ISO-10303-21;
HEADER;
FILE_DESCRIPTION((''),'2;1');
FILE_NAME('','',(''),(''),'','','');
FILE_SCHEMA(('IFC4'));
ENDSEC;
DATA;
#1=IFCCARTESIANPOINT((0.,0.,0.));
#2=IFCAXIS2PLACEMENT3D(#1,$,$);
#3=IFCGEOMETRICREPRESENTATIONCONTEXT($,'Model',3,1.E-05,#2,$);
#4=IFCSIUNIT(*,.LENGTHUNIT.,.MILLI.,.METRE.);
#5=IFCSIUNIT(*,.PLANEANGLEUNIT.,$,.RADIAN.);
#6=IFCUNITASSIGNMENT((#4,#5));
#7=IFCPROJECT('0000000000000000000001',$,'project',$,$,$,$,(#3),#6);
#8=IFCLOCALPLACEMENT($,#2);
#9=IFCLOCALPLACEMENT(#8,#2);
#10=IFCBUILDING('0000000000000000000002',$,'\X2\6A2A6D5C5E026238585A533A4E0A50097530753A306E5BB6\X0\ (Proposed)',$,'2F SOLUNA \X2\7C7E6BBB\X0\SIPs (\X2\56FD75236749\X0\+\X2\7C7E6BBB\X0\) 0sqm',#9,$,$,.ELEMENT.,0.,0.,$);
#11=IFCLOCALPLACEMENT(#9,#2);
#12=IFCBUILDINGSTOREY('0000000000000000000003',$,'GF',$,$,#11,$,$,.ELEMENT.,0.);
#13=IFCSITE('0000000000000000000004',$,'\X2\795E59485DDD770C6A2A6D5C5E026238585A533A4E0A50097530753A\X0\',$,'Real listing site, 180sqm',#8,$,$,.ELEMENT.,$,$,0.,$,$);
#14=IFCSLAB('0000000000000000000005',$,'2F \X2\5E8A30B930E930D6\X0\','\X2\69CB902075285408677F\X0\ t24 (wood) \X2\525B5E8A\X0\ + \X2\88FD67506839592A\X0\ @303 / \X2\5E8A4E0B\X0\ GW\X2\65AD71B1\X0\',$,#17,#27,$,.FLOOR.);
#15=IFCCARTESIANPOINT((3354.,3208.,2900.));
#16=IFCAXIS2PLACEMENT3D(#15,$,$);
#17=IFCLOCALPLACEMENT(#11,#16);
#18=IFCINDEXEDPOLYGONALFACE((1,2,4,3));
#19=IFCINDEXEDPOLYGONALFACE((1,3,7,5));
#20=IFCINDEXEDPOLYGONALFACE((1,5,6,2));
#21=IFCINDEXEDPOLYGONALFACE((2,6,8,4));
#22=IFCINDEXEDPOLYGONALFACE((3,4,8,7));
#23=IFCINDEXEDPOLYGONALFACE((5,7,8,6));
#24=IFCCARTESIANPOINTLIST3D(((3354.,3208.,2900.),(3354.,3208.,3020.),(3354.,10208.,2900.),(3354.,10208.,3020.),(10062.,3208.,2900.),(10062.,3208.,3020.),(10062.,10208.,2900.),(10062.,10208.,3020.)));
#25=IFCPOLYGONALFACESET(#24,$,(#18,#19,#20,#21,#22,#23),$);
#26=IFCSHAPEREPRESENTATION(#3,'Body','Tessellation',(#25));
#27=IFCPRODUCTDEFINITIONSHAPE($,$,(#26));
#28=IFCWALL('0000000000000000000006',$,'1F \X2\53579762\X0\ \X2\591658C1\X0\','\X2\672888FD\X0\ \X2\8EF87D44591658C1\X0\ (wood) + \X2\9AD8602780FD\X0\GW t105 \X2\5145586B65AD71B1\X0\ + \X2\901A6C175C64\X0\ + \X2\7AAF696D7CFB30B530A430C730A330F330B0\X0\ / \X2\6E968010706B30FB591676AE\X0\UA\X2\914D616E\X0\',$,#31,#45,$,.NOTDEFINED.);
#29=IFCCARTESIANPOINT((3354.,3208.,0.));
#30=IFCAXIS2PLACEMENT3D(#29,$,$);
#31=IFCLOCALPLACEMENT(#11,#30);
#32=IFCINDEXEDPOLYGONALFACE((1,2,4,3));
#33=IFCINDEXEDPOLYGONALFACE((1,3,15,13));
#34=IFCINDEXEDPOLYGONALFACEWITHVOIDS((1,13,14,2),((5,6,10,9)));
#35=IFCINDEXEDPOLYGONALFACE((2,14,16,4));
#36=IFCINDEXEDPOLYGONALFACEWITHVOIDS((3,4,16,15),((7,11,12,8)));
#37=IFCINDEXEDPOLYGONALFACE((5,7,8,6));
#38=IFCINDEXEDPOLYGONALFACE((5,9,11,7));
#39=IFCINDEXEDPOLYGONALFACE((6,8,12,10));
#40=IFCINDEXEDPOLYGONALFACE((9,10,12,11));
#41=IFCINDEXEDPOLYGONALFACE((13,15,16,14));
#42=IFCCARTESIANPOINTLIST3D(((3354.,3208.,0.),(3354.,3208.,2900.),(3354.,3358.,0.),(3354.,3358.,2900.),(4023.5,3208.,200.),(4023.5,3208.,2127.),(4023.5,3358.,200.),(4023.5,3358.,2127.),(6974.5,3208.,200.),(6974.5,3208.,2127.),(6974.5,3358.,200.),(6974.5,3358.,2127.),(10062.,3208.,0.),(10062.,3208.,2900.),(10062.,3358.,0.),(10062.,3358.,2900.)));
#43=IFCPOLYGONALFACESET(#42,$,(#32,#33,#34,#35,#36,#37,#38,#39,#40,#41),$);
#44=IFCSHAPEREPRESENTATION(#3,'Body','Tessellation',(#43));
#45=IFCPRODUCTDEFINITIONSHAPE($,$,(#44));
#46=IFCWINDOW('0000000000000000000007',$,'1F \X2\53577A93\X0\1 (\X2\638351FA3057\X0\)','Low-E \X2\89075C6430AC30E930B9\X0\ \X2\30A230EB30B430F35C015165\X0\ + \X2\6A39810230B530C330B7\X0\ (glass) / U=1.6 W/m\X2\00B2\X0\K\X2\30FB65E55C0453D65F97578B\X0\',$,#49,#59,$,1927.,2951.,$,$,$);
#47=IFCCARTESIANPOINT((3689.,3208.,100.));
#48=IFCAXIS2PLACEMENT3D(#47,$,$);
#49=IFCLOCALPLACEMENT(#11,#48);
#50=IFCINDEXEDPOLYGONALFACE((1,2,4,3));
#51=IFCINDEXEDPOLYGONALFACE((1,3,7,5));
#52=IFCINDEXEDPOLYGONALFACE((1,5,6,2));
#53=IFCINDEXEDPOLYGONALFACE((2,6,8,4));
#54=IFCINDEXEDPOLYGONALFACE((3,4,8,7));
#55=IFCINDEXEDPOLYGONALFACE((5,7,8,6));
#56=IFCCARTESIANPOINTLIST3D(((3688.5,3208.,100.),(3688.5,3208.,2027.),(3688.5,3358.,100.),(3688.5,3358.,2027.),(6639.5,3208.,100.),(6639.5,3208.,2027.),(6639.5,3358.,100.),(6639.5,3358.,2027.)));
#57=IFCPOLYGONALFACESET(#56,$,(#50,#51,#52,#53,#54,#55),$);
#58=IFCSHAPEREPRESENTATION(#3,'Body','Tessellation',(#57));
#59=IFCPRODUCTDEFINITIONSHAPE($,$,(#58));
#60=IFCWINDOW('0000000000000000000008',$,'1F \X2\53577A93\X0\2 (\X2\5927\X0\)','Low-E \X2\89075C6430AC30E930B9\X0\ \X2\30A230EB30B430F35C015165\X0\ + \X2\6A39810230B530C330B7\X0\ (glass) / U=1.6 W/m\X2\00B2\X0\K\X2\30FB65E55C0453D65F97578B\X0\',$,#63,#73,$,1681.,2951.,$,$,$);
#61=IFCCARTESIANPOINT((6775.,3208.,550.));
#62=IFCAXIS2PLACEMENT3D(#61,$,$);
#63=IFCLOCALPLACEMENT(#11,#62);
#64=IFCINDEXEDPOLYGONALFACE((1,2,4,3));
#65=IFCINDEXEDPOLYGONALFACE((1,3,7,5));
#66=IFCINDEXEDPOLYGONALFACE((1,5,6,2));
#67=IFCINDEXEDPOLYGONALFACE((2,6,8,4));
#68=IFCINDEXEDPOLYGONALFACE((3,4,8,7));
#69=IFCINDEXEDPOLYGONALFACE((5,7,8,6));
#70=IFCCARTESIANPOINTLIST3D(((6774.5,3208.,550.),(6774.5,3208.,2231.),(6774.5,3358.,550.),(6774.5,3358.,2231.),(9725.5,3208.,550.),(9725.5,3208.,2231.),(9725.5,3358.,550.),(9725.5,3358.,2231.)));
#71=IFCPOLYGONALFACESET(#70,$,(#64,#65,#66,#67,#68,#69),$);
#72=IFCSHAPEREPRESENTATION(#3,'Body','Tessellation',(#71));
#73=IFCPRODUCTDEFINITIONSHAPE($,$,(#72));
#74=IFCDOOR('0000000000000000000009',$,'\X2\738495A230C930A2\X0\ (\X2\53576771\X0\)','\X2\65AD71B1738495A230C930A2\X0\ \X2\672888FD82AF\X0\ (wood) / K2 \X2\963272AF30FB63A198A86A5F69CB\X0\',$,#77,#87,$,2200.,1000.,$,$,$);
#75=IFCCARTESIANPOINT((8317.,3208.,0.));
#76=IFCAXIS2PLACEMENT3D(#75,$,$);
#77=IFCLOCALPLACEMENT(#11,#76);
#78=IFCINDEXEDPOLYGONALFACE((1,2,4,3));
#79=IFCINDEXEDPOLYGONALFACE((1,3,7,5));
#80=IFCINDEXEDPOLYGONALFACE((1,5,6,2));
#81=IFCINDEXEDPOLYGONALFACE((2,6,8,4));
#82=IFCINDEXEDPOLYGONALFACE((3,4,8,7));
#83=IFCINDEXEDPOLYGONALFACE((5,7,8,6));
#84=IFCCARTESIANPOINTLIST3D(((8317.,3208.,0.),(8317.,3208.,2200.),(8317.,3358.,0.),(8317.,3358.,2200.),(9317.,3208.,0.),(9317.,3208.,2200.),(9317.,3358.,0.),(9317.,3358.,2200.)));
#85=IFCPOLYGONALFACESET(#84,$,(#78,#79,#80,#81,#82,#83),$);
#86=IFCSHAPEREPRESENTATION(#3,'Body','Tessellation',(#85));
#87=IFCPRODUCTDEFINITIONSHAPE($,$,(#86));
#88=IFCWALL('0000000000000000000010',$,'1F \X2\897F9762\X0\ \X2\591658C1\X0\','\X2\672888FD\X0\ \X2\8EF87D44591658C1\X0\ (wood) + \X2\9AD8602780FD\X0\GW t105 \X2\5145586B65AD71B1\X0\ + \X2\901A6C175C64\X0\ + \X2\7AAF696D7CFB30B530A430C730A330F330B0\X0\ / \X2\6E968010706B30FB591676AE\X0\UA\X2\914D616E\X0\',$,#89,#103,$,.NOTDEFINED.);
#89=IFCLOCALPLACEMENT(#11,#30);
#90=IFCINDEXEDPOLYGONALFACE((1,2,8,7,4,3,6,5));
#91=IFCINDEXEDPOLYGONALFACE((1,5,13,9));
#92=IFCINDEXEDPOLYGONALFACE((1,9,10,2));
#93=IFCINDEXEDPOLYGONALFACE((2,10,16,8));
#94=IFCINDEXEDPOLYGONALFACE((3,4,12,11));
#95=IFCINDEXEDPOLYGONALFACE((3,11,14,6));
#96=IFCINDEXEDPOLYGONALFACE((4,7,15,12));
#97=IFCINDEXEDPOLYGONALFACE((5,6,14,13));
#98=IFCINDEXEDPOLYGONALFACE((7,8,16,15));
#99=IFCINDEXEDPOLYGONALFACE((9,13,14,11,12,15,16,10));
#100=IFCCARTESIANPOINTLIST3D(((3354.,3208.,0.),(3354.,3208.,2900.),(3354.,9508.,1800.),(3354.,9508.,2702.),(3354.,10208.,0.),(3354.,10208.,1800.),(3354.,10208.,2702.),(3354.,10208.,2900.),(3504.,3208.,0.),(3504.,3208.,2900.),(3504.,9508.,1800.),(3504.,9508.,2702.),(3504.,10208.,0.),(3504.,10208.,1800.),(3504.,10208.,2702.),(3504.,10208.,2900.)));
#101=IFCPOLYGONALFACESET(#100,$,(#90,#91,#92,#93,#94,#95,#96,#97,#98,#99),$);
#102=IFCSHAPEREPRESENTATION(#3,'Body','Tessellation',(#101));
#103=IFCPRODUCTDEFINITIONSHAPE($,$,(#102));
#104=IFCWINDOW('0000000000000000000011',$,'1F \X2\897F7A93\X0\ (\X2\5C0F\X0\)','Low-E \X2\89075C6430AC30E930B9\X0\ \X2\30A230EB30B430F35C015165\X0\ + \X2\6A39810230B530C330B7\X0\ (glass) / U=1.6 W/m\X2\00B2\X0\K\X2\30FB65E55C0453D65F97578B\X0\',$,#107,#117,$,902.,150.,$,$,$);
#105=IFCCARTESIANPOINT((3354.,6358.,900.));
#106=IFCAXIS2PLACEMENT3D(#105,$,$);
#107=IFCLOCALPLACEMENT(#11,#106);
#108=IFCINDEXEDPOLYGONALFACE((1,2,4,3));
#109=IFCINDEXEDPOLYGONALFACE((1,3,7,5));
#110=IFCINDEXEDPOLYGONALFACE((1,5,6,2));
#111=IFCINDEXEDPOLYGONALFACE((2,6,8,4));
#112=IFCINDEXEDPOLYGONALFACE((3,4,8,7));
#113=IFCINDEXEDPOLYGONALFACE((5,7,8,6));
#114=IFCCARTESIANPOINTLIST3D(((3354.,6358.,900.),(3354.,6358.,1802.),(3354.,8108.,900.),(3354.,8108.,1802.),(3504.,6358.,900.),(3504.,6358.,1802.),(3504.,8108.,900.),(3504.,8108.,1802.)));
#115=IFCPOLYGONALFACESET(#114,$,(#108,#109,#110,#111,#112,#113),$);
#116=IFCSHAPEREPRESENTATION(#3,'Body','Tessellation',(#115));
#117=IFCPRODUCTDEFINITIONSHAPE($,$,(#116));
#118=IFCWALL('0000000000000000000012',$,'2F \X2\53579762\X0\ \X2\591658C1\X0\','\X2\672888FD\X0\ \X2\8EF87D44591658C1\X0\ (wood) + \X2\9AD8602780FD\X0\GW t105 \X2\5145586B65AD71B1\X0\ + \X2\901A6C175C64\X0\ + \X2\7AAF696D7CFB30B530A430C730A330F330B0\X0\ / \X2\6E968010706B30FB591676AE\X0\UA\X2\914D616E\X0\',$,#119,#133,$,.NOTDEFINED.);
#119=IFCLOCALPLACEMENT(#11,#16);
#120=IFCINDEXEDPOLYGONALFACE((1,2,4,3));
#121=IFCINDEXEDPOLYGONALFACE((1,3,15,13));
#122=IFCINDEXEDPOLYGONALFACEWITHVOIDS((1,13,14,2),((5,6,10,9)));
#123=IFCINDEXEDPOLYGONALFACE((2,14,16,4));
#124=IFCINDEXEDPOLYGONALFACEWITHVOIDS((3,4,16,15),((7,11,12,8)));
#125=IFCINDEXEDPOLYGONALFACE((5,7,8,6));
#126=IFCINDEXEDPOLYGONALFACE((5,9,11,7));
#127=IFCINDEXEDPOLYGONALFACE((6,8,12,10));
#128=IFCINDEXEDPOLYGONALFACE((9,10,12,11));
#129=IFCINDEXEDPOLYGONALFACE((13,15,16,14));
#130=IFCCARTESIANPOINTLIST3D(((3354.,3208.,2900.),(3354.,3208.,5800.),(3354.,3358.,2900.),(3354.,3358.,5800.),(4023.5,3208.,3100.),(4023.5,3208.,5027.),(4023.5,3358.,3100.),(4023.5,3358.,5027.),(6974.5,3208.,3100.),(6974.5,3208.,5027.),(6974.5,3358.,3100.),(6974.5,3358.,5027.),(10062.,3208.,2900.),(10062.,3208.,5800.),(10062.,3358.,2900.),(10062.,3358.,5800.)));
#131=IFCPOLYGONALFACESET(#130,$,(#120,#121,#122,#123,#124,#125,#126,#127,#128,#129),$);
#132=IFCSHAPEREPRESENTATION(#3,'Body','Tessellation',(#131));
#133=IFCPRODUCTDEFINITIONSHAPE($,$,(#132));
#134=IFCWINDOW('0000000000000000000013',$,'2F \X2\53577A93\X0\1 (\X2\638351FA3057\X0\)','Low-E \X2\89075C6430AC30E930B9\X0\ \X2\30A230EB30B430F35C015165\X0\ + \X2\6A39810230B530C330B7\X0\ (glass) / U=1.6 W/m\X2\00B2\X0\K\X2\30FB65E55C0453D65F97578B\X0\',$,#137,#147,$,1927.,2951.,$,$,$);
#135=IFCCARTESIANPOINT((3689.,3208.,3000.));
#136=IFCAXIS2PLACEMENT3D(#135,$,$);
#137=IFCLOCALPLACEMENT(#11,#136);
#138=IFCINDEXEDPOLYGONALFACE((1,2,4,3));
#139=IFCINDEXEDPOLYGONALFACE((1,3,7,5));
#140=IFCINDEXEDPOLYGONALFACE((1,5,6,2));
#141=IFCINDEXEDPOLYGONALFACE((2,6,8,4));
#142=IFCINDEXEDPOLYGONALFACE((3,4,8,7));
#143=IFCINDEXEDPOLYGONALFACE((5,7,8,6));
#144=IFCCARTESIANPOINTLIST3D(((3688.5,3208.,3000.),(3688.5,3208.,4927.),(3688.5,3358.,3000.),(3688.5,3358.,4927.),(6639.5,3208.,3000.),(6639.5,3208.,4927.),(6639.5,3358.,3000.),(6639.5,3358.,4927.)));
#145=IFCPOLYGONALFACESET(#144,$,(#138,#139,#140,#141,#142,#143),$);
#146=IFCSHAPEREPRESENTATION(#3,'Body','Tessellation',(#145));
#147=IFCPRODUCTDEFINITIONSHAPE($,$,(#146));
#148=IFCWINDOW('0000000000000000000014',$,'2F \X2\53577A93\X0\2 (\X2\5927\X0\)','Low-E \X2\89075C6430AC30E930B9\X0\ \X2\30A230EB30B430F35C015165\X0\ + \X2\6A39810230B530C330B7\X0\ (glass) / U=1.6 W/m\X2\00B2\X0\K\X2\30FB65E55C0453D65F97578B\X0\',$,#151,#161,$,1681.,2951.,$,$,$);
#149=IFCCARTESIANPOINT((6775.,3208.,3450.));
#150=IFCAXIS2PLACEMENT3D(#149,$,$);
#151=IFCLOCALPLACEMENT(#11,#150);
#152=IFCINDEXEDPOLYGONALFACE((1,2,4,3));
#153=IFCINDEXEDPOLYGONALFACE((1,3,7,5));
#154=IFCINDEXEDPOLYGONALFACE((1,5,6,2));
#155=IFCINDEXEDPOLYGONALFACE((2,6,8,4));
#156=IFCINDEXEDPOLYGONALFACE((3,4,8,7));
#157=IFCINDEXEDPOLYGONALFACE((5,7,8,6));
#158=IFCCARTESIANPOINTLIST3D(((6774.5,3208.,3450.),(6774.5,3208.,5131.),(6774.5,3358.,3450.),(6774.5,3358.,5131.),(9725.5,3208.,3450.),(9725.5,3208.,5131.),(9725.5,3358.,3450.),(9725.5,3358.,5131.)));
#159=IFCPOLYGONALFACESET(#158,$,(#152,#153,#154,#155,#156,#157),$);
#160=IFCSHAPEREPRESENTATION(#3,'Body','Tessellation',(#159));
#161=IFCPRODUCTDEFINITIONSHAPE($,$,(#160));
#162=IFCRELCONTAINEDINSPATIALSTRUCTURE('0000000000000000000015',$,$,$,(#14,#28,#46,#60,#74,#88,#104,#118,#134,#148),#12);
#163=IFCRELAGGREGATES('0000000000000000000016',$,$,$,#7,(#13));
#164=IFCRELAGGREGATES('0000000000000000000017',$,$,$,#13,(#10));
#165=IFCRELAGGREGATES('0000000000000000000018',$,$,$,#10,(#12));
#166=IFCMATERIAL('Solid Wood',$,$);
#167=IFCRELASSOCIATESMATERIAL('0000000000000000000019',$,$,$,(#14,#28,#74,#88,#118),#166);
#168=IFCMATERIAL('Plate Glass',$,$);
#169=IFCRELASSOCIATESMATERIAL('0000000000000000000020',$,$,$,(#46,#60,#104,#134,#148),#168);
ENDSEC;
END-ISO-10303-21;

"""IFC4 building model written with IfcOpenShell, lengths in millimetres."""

from ifc_helpers import new_model, si_unit, frame, frame_2d, origin, place, context, project, spatial, rectangle, extrude, material, element, fill, save


model = new_model("IFC4")

# Units and contexts
model_context = context("Model", 3, precision=1e-05, world=origin())
ifc_project = project(units=[si_unit("LENGTHUNIT", "METRE", prefix="MILLI"), si_unit("PLANEANGLEUNIT", "RADIAN")], contexts=[model_context])

# Site, building, storey
site_placement = place(None, origin())
site = spatial("IfcSite", under=ifc_project, at=site_placement, Name="神奈川県横浜市戸塚区上倉田町", ObjectType="Real listing site, 180sqm", CompositionType="ELEMENT", RefElevation=0.0)
building_placement = place(site_placement, origin())
building = spatial("IfcBuilding", under=site, at=building_placement, Name="横浜市戸塚区上倉田町の家 (Proposed)", ObjectType="2F SOLUNA 籾殻SIPs (国産杉+籾殻) 0sqm", CompositionType="ELEMENT", ElevationOfRefHeight=0.0, ElevationOfTerrain=0.0)
storey_placement = place(building_placement, origin())
storey = spatial("IfcBuildingStorey", under=building, at=storey_placement, Name="GF", CompositionType="ELEMENT", Elevation=0.0)

# Slab
ifc_material_1 = material(Name="Solid Wood")
slab_1_placement = place(storey_placement, frame((3354.0, 3208.0, 2900.0)))
element("IfcSlab", 1, at=slab_1_placement, inside=storey, material=ifc_material_1, Name="2F 床スラブ", Description="構造用合板 t24 (wood) 剛床 + 製材根太 @303 / 床下 GW断熱", PredefinedType="FLOOR", context=model_context, shape_type="SweptSolid", body=[
    extrude(rectangle(XDim=6708.0, YDim=7000.0, at=frame_2d((3354.0, 3500.0))), frame((3354.0, 3208.0, 2900.0)), (0.0, 0.0, 1.0), 120.0),
])

# Wall, openings, windows, door
wall_1_placement = place(storey_placement, frame((3354.0, 3208.0, 0.0)))
wall_1 = element("IfcWall", 2, at=wall_1_placement, inside=storey, material=ifc_material_1, Name="1F 南面 外壁", Description="木製 軸組外壁 (wood) + 高性能GW t105 充填断熱 + 通気層 + 窯業系サイディング / 準耐火・外皮UA配慮", PredefinedType="NOTDEFINED", context=model_context, shape_type="SweptSolid", body=[
    extrude(rectangle(XDim=6708.0, YDim=150.0, at=frame_2d((3354.0, 75.0))), frame((3354.0, 3208.0, 0.0)), (0.0, 0.0, 1.0), 2900.0),
])
opening_1_placement = place(storey_placement, frame((3689.0, 3208.0, 100.0)))
opening_1 = element("IfcOpeningElement", 3, at=opening_1_placement, cuts=wall_1, PredefinedType="NOTDEFINED", context=model_context, shape_type="SweptSolid", body=[
    extrude(rectangle(XDim=2951.0, YDim=150.0, at=frame_2d((1475.0, 75.0))), frame((3689.0, 3208.0, 100.0)), (0.0, 0.0, 1.0), 1927.0),
])
opening_2_placement = place(storey_placement, frame((6775.0, 3208.0, 550.0)))
opening_2 = element("IfcOpeningElement", 4, at=opening_2_placement, cuts=wall_1, PredefinedType="NOTDEFINED", context=model_context, shape_type="SweptSolid", body=[
    extrude(rectangle(XDim=2951.0, YDim=150.0, at=frame_2d((1475.0, 75.0))), frame((6775.0, 3208.0, 550.0)), (0.0, 0.0, 1.0), 1681.0),
])
opening_3_placement = place(storey_placement, frame((8317.0, 3208.0, 0.0)))
opening_3 = element("IfcOpeningElement", 5, at=opening_3_placement, cuts=wall_1, PredefinedType="NOTDEFINED", context=model_context, shape_type="SweptSolid", body=[
    extrude(rectangle(XDim=1000.0, YDim=150.0, at=frame_2d((500.0, 75.0))), frame((8317.0, 3208.0, 0.0)), (0.0, 0.0, 1.0), 2200.0),
])
ifc_material_2 = material(Name="Plate Glass")
window_1_placement = place(storey_placement, frame((3689.0, 3208.0, 100.0)))
window_1 = element("IfcWindow", 6, at=window_1_placement, inside=storey, material=ifc_material_2, Name="1F 南窓1 (掃出し)", Description="Low-E 複層ガラス アルゴン封入 + 樹脂サッシ (glass) / U=1.6 W/m²K・日射取得型", OverallHeight=1927.0, OverallWidth=2951.0, context=model_context, shape_type="SweptSolid", body=[
    extrude(rectangle(XDim=2951.0, YDim=150.0, at=frame_2d((1475.0, 75.0))), frame((3689.0, 3208.0, 100.0)), (0.0, 0.0, 1.0), 1927.0),
])
fill(opening_1, window_1)
window_2_placement = place(storey_placement, frame((6775.0, 3208.0, 550.0)))
window_2 = element("IfcWindow", 7, at=window_2_placement, inside=storey, material=ifc_material_2, Name="1F 南窓2 (大)", Description="Low-E 複層ガラス アルゴン封入 + 樹脂サッシ (glass) / U=1.6 W/m²K・日射取得型", OverallHeight=1681.0, OverallWidth=2951.0, context=model_context, shape_type="SweptSolid", body=[
    extrude(rectangle(XDim=2951.0, YDim=150.0, at=frame_2d((1475.0, 75.0))), frame((6775.0, 3208.0, 550.0)), (0.0, 0.0, 1.0), 1681.0),
])
fill(opening_2, window_2)
door_placement = place(storey_placement, frame((8317.0, 3208.0, 0.0)))
door = element("IfcDoor", 8, at=door_placement, inside=storey, material=ifc_material_1, Name="玄関ドア (南東)", Description="断熱玄関ドア 木製芯 (wood) / K2 防犯・採風機構", OverallHeight=2200.0, OverallWidth=1000.0, context=model_context, shape_type="SweptSolid", body=[
    extrude(rectangle(XDim=1000.0, YDim=150.0, at=frame_2d((500.0, 75.0))), frame((8317.0, 3208.0, 0.0)), (0.0, 0.0, 1.0), 2200.0),
])
fill(opening_3, door)

# Wall, opening, window
wall_2_placement = place(storey_placement, frame((3354.0, 3208.0, 0.0)))
wall_2 = element("IfcWall", 9, at=wall_2_placement, inside=storey, material=ifc_material_1, Name="1F 西面 外壁", Description="木製 軸組外壁 (wood) + 高性能GW t105 充填断熱 + 通気層 + 窯業系サイディング / 準耐火・外皮UA配慮", PredefinedType="NOTDEFINED", context=model_context, shape_type="SweptSolid", body=[
    extrude(rectangle(XDim=150.0, YDim=7000.0, at=frame_2d((75.0, 3500.0))), frame((3354.0, 3208.0, 0.0)), (0.0, 0.0, 1.0), 2900.0),
])
opening_4_placement = place(storey_placement, frame((3354.0, 6358.0, 900.0)))
opening_4 = element("IfcOpeningElement", 10, at=opening_4_placement, cuts=wall_2, PredefinedType="NOTDEFINED", context=model_context, shape_type="SweptSolid", body=[
    extrude(rectangle(XDim=150.0, YDim=1750.0, at=frame_2d((75.0, 875.0))), frame((3354.0, 6358.0, 900.0)), (0.0, 0.0, 1.0), 902.0),
])
window_3_placement = place(storey_placement, frame((3354.0, 6358.0, 900.0)))
window_3 = element("IfcWindow", 11, at=window_3_placement, inside=storey, material=ifc_material_2, Name="1F 西窓 (小)", Description="Low-E 複層ガラス アルゴン封入 + 樹脂サッシ (glass) / U=1.6 W/m²K・日射取得型", OverallHeight=902.0, OverallWidth=150.0, context=model_context, shape_type="SweptSolid", body=[
    extrude(rectangle(XDim=150.0, YDim=1750.0, at=frame_2d((75.0, 875.0))), frame((3354.0, 6358.0, 900.0)), (0.0, 0.0, 1.0), 902.0),
])
fill(opening_4, window_3)

# Wall, openings, windows
wall_3_placement = place(storey_placement, frame((3354.0, 3208.0, 2900.0)))
wall_3 = element("IfcWall", 12, at=wall_3_placement, inside=storey, material=ifc_material_1, Name="2F 南面 外壁", Description="木製 軸組外壁 (wood) + 高性能GW t105 充填断熱 + 通気層 + 窯業系サイディング / 準耐火・外皮UA配慮", PredefinedType="NOTDEFINED", context=model_context, shape_type="SweptSolid", body=[
    extrude(rectangle(XDim=6708.0, YDim=150.0, at=frame_2d((3354.0, 75.0))), frame((3354.0, 3208.0, 2900.0)), (0.0, 0.0, 1.0), 2900.0),
])
opening_5_placement = place(storey_placement, frame((3689.0, 3208.0, 3000.0)))
opening_5 = element("IfcOpeningElement", 13, at=opening_5_placement, cuts=wall_3, PredefinedType="NOTDEFINED", context=model_context, shape_type="SweptSolid", body=[
    extrude(rectangle(XDim=2951.0, YDim=150.0, at=frame_2d((1475.0, 75.0))), frame((3689.0, 3208.0, 3000.0)), (0.0, 0.0, 1.0), 1927.0),
])
opening_6_placement = place(storey_placement, frame((6775.0, 3208.0, 3450.0)))
opening_6 = element("IfcOpeningElement", 14, at=opening_6_placement, cuts=wall_3, PredefinedType="NOTDEFINED", context=model_context, shape_type="SweptSolid", body=[
    extrude(rectangle(XDim=2951.0, YDim=150.0, at=frame_2d((1475.0, 75.0))), frame((6775.0, 3208.0, 3450.0)), (0.0, 0.0, 1.0), 1681.0),
])
window_4_placement = place(storey_placement, frame((3689.0, 3208.0, 3000.0)))
window_4 = element("IfcWindow", 15, at=window_4_placement, inside=storey, material=ifc_material_2, Name="2F 南窓1 (掃出し)", Description="Low-E 複層ガラス アルゴン封入 + 樹脂サッシ (glass) / U=1.6 W/m²K・日射取得型", OverallHeight=1927.0, OverallWidth=2951.0, context=model_context, shape_type="SweptSolid", body=[
    extrude(rectangle(XDim=2951.0, YDim=150.0, at=frame_2d((1475.0, 75.0))), frame((3689.0, 3208.0, 3000.0)), (0.0, 0.0, 1.0), 1927.0),
])
fill(opening_5, window_4)
window_5_placement = place(storey_placement, frame((6775.0, 3208.0, 3450.0)))
window_5 = element("IfcWindow", 16, at=window_5_placement, inside=storey, material=ifc_material_2, Name="2F 南窓2 (大)", Description="Low-E 複層ガラス アルゴン封入 + 樹脂サッシ (glass) / U=1.6 W/m²K・日射取得型", OverallHeight=1681.0, OverallWidth=2951.0, context=model_context, shape_type="SweptSolid", body=[
    extrude(rectangle(XDim=2951.0, YDim=150.0, at=frame_2d((1475.0, 75.0))), frame((6775.0, 3208.0, 3450.0)), (0.0, 0.0, 1.0), 1681.0),
])
fill(opening_6, window_5)

save(model, "model.ifc")
